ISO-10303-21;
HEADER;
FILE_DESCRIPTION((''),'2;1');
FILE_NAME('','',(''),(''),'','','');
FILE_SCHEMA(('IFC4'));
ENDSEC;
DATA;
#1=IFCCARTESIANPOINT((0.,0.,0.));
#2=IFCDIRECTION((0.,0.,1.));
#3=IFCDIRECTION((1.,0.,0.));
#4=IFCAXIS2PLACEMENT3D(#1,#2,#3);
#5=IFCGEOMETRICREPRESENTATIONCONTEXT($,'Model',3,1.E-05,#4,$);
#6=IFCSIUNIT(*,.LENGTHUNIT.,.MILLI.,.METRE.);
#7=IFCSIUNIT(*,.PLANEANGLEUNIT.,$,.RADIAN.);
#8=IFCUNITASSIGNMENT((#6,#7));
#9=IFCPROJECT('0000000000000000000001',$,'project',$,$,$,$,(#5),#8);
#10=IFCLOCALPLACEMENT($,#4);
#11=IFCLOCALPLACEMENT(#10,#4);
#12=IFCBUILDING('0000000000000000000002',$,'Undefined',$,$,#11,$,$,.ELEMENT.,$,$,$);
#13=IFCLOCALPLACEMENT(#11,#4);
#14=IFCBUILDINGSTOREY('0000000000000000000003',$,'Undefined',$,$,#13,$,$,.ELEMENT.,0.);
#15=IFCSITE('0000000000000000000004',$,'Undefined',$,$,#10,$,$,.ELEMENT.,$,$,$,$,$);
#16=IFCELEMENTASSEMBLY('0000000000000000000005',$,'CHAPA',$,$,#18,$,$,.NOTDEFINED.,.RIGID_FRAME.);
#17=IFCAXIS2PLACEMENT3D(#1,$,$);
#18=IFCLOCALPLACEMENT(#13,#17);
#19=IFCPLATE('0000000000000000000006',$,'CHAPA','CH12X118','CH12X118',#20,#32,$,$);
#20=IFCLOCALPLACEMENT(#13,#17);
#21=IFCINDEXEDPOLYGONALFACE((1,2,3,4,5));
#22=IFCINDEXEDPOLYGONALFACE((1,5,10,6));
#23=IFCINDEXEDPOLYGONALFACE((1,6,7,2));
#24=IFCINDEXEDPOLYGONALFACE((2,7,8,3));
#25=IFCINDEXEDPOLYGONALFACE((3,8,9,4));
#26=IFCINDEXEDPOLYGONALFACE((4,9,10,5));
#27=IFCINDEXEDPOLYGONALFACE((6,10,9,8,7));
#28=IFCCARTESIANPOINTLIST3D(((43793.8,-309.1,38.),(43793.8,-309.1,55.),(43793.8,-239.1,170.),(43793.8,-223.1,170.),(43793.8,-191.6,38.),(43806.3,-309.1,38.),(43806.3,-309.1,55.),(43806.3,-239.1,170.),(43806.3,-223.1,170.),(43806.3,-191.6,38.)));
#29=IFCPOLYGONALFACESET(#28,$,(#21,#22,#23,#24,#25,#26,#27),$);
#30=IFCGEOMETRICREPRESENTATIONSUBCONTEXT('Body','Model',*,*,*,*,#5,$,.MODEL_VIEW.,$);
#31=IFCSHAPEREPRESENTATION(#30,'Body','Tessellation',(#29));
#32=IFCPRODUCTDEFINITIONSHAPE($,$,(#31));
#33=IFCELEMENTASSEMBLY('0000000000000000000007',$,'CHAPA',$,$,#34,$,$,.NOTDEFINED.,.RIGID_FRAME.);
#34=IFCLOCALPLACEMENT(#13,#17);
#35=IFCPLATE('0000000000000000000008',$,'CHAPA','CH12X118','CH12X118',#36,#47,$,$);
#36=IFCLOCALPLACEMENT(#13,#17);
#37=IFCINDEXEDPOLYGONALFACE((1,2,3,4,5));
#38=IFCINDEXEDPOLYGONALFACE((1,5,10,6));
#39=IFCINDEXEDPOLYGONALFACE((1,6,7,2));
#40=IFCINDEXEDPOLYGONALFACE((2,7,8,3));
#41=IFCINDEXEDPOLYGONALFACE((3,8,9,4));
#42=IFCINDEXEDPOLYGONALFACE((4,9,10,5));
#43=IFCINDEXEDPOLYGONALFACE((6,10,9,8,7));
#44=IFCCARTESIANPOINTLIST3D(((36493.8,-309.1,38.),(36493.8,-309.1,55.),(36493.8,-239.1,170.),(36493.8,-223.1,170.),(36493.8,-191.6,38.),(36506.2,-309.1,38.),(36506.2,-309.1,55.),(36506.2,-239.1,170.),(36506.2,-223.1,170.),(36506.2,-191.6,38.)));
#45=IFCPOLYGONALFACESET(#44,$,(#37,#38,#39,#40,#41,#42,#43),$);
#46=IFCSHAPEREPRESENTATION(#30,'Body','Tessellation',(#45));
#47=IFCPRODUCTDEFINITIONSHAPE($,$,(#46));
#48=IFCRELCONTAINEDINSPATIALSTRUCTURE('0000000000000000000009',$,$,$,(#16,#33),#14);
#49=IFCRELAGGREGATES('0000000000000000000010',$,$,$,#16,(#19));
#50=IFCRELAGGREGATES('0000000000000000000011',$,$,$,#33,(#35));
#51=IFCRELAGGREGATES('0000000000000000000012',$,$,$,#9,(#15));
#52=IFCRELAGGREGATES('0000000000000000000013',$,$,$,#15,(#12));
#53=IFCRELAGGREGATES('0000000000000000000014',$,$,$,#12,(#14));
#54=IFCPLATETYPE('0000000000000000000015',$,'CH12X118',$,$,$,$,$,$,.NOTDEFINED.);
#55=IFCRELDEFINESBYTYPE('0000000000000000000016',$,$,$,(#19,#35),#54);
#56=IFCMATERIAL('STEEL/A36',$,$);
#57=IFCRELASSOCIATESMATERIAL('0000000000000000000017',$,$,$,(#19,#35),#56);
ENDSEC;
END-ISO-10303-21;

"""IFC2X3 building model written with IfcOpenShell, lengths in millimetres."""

from ifc_helpers import new_model, si_unit, frame, origin_with_axes, place, context, subcontext, project, spatial, polyline, outline, extrude, material, type_object, element, aggregate, save


model = new_model("IFC2X3")

# Units and contexts
model_context = context("Model", 3, precision=1e-05, world=origin_with_axes())
body_context = subcontext(model_context, "Body", "Model", "MODEL_VIEW")
ifc_project = project(units=[si_unit("LENGTHUNIT", "METRE", prefix="MILLI"), si_unit("PLANEANGLEUNIT", "RADIAN")], contexts=[model_context])

# Site, building, storey
site_placement = place(None, origin_with_axes())
site = spatial("IfcSite", under=ifc_project, at=site_placement, Name="Undefined", CompositionType="ELEMENT")
building_placement = place(site_placement, origin_with_axes())
building = spatial("IfcBuilding", under=site, at=building_placement, Name="Undefined", CompositionType="ELEMENT")
storey_placement = place(building_placement, origin_with_axes())
storey = spatial("IfcBuildingStorey", under=building, at=storey_placement, Name="Undefined", CompositionType="ELEMENT", Elevation=0.0)

# Element assembly
assembly_1_placement = place(storey_placement, origin_with_axes())
assembly_1 = element("IfcElementAssembly", 1, at=assembly_1_placement, inside=storey, Name="CHAPA", AssemblyPlace="NOTDEFINED", PredefinedType="RIGID_FRAME")
ifc_material_1 = material(Name="STEEL/A36")

# Plate
plate_type_1 = type_object("IfcPlateType", Name="CH12X118", PredefinedType="NOTDEFINED")
plate_1_placement = place(assembly_1_placement, frame((43800.0, -309.1, 38.0), z_axis=(1.0, 0.0, 0.0), x_axis=(0.0, 1.0, 0.0)))
plate_1 = element("IfcPlate", 2, at=plate_1_placement, type_object=plate_type_1, material=ifc_material_1, Name="CHAPA", Description="CH12X118", ObjectType="CH12X118", context=body_context, shape_type="SweptSolid", body=[
    extrude(outline(polyline([(0.0, 0.0), (117.5, 0.0), (85.9, 132.0), (70.0, 132.0), (0.0, 17.0), (0.0, 0.0)])), frame((0.0, 0.0, -6.2), z_axis=(0.0, 0.0, 1.0), x_axis=(1.0, 0.0, 0.0)), (0.0, 0.0, 1.0), 12.5),
])

# Element assembly, plate
assembly_2_placement = place(storey_placement, origin_with_axes())
assembly_2 = element("IfcElementAssembly", 3, at=assembly_2_placement, inside=storey, Name="CHAPA", AssemblyPlace="NOTDEFINED", PredefinedType="RIGID_FRAME")
plate_2_placement = place(assembly_2_placement, frame((36500.0, -309.1, 38.0), z_axis=(1.0, 0.0, 0.0), x_axis=(0.0, 1.0, 0.0)))
plate_2 = element("IfcPlate", 4, at=plate_2_placement, type_object=plate_type_1, material=ifc_material_1, Name="CHAPA", Description="CH12X118", ObjectType="CH12X118", context=body_context, shape_type="SweptSolid", body=[
    extrude(outline(polyline([(0.0, 0.0), (117.5, 0.0), (85.9, 132.0), (70.0, 132.0), (0.0, 17.0), (0.0, 0.0)])), frame((0.0, 0.0, -6.2), z_axis=(0.0, 0.0, 1.0), x_axis=(1.0, 0.0, 0.0)), (0.0, 0.0, 1.0), 12.5),
])

aggregate(assembly_1, [plate_1])
aggregate(assembly_2, [plate_2])

save(model, "model.ifc")
